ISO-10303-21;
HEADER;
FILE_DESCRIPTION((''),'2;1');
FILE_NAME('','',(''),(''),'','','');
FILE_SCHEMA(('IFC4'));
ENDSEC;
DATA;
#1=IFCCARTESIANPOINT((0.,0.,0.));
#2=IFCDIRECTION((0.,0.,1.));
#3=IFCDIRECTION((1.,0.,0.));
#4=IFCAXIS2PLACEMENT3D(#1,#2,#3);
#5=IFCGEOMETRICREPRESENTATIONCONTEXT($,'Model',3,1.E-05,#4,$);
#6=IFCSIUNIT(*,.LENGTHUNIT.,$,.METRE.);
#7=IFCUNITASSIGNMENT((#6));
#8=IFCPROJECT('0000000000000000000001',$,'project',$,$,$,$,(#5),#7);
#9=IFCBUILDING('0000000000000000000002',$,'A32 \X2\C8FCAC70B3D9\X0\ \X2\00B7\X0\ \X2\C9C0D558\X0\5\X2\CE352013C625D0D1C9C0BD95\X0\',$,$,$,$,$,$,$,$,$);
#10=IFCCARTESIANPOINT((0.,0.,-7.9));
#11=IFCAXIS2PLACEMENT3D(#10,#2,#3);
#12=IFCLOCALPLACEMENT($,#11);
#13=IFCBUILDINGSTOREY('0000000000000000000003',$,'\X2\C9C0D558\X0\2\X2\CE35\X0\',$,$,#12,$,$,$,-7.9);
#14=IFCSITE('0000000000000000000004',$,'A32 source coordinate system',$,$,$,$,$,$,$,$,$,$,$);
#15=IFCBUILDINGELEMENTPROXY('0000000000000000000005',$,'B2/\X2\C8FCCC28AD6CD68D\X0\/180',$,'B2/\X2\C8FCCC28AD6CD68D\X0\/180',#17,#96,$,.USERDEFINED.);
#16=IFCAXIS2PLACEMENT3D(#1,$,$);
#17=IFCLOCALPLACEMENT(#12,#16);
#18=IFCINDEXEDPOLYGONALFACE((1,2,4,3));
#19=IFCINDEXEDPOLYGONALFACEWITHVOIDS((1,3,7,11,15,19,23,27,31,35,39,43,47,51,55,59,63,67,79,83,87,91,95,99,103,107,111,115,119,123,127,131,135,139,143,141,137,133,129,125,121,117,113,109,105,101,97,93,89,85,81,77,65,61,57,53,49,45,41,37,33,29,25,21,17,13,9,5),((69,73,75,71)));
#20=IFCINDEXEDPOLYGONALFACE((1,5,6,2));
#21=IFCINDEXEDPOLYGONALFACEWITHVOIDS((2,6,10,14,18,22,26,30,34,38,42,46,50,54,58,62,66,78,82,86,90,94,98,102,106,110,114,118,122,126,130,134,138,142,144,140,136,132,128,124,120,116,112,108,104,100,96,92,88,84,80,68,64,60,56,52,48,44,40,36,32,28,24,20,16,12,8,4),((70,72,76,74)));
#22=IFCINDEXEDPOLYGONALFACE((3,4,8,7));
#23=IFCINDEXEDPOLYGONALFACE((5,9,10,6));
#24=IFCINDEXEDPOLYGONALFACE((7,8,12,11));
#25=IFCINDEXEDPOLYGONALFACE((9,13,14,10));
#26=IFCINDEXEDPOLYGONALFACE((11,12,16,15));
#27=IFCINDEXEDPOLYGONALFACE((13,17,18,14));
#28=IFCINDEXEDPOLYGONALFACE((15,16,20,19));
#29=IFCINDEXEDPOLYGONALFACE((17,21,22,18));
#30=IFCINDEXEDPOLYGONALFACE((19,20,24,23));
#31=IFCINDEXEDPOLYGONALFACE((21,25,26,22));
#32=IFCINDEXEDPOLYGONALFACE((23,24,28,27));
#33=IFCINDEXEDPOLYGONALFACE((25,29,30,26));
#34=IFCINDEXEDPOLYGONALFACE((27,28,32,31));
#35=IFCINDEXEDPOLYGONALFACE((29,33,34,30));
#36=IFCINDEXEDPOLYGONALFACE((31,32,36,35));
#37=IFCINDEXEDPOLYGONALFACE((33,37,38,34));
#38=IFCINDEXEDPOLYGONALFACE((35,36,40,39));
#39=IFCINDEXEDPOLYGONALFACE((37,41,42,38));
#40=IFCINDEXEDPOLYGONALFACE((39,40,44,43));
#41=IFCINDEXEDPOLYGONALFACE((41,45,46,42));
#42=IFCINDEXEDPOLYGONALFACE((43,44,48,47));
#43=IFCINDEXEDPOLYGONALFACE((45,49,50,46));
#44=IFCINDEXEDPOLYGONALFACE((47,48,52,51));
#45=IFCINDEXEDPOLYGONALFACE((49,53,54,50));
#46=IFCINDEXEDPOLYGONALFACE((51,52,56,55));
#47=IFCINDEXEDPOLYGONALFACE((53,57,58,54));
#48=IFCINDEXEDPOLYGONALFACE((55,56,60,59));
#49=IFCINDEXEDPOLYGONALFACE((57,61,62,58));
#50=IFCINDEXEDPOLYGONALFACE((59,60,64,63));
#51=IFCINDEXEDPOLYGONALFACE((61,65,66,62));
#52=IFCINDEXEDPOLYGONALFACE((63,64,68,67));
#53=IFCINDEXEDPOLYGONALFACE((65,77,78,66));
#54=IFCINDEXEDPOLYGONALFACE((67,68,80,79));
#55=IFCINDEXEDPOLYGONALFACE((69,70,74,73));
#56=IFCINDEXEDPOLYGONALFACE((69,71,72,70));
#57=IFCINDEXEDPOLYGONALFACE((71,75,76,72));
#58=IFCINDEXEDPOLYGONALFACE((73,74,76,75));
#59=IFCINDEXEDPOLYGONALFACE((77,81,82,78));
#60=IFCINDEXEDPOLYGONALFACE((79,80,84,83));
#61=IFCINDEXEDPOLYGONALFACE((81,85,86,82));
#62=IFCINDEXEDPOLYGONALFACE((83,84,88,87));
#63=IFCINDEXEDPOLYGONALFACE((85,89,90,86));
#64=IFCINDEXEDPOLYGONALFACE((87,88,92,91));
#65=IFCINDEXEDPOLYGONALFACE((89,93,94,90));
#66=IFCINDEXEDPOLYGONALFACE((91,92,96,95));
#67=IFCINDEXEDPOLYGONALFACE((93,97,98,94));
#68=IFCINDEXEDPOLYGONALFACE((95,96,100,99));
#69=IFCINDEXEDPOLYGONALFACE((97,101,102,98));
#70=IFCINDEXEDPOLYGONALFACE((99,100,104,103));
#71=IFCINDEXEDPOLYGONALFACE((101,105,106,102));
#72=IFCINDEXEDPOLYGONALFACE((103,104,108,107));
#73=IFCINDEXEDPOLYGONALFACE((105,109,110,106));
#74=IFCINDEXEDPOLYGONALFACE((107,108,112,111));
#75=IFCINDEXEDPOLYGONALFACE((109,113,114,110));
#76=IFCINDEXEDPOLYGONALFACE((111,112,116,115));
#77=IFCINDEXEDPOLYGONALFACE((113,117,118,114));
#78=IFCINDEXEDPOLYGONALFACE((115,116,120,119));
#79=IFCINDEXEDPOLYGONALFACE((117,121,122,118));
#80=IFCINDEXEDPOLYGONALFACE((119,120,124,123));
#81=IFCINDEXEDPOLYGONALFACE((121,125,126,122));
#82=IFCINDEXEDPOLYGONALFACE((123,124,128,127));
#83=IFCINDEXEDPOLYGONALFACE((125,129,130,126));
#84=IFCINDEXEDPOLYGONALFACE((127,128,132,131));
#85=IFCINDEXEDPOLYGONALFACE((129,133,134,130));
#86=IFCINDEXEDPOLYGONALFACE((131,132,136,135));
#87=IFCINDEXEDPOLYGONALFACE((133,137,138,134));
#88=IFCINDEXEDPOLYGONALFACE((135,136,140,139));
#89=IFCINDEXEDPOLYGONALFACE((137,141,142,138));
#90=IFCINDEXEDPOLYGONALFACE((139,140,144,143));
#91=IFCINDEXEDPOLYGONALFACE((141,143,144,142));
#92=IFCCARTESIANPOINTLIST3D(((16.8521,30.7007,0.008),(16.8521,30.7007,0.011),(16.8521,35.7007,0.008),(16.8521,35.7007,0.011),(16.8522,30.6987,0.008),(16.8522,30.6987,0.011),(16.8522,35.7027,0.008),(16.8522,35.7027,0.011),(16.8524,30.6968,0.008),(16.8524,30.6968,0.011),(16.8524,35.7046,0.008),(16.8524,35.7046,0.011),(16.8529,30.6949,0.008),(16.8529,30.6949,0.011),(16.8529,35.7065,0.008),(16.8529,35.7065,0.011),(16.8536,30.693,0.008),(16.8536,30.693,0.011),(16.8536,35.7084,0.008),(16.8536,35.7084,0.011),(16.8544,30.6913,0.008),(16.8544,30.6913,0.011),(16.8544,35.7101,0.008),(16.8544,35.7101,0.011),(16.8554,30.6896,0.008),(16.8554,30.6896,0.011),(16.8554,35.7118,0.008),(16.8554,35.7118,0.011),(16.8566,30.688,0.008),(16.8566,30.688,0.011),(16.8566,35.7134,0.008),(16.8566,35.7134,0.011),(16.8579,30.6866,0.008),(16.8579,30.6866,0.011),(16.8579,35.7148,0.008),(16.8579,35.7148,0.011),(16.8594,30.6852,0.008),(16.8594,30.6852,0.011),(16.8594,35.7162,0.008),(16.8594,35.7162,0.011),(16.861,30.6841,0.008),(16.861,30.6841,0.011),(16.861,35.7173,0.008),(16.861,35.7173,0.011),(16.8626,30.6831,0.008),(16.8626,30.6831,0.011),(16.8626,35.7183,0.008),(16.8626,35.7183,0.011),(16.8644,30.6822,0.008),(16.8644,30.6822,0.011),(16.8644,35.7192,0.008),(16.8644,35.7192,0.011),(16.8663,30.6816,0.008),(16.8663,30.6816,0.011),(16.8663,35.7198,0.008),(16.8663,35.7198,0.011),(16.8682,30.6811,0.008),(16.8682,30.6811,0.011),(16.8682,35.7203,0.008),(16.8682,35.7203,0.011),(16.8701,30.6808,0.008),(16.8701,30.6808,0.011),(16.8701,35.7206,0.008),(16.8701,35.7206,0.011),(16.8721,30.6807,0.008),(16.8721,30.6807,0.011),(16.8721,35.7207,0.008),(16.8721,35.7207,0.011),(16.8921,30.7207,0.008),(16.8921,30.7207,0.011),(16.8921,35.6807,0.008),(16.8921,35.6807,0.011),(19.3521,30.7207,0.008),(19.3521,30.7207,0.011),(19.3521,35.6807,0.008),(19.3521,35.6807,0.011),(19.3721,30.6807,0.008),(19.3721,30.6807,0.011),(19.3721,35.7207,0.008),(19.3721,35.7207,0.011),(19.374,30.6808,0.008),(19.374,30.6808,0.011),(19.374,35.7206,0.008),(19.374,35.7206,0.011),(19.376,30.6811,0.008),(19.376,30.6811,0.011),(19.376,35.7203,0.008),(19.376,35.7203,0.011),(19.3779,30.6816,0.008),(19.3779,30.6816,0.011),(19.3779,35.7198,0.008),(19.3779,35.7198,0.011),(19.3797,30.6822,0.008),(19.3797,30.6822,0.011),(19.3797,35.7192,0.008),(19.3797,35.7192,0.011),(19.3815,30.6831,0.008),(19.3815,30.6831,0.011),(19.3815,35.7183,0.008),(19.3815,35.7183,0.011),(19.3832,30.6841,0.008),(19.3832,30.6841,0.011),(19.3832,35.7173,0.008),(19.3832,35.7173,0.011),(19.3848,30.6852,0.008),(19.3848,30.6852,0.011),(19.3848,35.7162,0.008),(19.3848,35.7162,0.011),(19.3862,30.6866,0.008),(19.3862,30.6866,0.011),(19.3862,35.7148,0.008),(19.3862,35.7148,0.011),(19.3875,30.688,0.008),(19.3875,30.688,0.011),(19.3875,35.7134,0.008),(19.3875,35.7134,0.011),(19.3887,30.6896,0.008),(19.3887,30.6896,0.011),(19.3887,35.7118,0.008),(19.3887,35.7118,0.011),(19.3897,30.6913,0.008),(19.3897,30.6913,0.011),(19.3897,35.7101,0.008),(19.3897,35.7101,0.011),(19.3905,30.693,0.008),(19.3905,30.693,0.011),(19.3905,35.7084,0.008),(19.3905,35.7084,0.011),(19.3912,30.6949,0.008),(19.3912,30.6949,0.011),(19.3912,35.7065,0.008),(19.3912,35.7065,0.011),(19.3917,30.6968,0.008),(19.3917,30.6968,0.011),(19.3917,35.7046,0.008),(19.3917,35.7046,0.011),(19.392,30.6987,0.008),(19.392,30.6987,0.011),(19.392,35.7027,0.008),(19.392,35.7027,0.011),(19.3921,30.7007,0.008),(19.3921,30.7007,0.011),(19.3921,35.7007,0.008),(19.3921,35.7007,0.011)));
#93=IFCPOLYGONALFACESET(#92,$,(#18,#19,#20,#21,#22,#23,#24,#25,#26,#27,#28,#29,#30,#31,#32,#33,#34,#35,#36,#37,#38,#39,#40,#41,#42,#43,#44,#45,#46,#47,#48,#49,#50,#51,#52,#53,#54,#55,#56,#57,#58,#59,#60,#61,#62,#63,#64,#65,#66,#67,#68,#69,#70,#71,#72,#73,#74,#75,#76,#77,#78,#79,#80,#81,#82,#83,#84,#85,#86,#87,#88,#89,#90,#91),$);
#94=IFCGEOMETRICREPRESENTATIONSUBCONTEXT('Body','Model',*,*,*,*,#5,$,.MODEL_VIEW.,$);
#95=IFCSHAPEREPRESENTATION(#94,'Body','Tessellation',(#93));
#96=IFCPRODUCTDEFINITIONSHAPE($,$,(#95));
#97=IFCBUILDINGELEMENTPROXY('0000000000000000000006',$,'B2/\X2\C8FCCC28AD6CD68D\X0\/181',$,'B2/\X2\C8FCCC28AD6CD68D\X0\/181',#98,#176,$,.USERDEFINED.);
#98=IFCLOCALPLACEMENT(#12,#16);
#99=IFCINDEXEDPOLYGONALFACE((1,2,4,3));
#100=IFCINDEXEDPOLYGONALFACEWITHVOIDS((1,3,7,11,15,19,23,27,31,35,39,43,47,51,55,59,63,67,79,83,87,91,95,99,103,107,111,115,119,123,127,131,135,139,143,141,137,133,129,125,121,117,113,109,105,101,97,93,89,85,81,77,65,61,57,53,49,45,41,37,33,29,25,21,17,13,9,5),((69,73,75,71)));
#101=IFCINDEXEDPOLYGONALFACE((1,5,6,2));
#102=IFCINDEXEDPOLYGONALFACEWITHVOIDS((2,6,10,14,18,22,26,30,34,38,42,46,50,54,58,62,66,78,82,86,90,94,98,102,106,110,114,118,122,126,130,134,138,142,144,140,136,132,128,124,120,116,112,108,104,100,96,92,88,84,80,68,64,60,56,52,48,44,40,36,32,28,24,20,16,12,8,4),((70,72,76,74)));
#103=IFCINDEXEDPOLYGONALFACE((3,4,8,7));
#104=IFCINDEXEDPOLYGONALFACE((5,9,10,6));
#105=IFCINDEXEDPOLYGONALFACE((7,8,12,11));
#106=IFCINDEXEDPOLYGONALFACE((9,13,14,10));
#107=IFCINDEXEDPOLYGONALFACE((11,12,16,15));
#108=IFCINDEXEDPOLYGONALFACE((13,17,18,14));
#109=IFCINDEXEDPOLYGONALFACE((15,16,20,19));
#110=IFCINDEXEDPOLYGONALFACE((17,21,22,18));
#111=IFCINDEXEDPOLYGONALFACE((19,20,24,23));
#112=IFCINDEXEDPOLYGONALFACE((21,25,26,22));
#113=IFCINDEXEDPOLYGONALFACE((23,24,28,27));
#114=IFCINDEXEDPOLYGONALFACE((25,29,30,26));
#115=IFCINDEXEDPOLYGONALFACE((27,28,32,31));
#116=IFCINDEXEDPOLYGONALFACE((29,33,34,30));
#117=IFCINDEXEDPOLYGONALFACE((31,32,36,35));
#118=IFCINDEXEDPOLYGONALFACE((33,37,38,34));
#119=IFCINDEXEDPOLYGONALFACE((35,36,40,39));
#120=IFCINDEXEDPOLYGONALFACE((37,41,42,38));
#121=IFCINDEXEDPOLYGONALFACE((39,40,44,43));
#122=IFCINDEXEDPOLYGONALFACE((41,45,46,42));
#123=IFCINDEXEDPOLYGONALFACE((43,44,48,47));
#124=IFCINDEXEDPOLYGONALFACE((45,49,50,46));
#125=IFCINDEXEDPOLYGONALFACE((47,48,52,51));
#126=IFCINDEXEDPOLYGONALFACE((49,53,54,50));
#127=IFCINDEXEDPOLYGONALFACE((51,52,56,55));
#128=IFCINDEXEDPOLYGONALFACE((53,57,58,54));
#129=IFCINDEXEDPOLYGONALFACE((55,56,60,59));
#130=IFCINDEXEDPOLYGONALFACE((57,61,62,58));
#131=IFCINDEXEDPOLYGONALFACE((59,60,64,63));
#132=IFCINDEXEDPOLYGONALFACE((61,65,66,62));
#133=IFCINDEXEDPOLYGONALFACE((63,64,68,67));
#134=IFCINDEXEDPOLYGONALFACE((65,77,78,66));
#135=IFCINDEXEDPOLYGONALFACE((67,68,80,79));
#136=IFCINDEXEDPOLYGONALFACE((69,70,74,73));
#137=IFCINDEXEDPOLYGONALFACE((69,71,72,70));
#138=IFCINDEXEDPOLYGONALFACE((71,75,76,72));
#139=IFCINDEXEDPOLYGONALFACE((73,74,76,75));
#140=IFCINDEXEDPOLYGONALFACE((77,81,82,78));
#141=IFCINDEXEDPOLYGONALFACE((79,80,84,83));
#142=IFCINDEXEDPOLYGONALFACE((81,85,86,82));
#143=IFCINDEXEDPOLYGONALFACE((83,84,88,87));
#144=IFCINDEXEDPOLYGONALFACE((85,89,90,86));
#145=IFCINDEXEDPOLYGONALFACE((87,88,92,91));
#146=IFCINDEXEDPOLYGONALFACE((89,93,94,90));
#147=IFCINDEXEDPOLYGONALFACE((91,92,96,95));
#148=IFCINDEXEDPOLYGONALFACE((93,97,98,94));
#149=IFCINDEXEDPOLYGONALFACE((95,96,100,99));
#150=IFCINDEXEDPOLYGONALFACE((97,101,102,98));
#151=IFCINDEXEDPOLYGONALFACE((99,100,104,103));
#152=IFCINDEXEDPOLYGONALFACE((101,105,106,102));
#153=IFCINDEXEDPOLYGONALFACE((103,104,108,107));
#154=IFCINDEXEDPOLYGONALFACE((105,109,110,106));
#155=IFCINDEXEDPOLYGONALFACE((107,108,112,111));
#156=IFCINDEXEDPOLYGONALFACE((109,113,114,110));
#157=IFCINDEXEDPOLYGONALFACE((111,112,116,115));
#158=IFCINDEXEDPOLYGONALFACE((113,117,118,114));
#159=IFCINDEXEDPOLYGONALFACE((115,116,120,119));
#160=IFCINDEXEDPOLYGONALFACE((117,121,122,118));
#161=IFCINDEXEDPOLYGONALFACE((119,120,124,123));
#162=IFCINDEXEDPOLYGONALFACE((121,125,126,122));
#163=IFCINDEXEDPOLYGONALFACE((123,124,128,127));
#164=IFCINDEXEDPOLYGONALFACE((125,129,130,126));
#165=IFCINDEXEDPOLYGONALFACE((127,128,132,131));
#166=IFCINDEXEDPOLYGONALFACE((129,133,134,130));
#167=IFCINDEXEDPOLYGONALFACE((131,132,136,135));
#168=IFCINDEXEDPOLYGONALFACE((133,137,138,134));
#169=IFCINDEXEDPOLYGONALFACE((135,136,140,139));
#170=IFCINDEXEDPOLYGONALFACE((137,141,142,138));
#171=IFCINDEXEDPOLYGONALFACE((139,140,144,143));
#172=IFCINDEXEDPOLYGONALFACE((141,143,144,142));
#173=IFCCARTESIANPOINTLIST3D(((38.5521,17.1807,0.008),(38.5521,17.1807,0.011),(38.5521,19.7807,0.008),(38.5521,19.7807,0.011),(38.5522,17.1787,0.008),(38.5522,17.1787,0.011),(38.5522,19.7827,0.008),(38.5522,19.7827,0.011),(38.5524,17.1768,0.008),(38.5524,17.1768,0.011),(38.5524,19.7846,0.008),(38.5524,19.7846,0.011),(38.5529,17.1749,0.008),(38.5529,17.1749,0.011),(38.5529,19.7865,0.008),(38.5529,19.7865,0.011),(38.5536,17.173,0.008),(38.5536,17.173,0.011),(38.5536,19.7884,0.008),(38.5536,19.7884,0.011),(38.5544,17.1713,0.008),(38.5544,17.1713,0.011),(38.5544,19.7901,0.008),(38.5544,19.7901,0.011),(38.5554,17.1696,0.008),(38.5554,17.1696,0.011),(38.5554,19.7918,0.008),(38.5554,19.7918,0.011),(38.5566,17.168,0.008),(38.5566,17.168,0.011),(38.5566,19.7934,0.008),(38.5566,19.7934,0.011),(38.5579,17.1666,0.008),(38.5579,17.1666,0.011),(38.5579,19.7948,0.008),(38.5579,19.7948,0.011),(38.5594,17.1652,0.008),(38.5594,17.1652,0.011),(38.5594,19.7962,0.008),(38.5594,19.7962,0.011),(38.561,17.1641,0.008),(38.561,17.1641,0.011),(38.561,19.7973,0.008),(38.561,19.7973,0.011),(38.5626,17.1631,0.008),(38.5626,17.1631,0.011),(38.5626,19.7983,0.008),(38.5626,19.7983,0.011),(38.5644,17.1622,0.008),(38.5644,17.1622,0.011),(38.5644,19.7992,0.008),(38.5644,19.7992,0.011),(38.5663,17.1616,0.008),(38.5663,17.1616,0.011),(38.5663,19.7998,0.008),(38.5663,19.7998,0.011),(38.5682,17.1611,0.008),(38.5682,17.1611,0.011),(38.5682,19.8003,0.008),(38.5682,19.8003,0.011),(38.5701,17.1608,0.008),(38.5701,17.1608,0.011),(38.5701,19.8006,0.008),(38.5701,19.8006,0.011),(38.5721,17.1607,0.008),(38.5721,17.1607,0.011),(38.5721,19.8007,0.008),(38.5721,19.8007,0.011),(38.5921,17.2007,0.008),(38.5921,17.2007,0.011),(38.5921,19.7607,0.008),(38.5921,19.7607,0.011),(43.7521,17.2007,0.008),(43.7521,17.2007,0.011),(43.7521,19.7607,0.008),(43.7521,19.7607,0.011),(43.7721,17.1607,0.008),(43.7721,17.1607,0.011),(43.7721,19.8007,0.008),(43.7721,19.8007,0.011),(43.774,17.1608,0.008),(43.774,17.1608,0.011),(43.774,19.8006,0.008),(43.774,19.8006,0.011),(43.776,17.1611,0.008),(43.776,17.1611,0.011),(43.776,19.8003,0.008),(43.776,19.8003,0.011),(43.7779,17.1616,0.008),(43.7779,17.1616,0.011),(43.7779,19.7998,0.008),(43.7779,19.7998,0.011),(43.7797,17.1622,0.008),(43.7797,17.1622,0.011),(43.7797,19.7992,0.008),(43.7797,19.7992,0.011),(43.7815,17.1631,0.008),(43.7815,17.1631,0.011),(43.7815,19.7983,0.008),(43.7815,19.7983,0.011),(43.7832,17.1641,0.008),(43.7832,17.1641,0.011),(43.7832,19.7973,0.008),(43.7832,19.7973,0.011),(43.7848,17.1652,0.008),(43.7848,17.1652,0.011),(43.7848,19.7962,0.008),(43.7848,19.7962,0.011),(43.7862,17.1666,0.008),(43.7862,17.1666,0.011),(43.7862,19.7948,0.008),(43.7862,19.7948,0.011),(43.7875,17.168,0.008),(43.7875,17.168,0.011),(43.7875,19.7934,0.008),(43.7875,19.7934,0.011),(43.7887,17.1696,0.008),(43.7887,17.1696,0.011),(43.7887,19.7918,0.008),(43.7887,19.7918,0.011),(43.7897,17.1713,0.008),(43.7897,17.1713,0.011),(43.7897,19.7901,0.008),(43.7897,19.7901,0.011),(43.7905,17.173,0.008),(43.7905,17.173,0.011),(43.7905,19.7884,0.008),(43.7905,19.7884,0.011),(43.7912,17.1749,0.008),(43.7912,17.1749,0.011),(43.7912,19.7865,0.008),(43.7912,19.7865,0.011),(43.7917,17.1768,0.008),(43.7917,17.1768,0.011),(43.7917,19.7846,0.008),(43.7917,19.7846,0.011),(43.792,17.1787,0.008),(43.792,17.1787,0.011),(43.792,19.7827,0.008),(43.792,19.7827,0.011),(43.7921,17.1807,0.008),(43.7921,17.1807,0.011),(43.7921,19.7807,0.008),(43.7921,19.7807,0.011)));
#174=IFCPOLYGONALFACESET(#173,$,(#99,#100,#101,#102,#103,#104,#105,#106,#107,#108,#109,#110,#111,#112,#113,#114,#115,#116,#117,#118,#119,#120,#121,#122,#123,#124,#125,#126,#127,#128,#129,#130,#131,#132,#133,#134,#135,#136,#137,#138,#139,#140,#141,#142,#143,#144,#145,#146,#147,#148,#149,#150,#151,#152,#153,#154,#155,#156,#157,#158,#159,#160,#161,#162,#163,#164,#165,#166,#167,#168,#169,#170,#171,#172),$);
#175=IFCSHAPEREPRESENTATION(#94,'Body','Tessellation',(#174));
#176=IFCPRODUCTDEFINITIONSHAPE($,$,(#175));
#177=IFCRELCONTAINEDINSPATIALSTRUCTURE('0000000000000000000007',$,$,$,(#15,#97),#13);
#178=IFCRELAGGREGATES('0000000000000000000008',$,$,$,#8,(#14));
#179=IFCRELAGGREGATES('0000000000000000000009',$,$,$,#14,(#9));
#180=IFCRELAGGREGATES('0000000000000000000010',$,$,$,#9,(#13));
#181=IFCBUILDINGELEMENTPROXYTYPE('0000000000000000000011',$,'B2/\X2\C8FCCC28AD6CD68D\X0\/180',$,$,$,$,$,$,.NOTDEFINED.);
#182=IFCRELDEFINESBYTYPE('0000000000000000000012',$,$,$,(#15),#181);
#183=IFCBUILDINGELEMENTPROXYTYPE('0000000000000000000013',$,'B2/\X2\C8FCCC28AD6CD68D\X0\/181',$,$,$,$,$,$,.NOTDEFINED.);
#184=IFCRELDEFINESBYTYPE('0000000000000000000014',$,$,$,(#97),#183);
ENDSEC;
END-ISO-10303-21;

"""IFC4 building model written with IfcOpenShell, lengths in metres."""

from ifc_helpers import new_model, si_unit, frame, origin, origin_with_axes, place, context, subcontext, project, spatial, polyline, outline, extrude, source, transform, mapped, type_object, type_shapes, element, save


model = new_model("IFC4")

# Units and contexts
model_context = context("Model", 3, precision=1e-05, world=origin_with_axes())
body_context = subcontext(model_context, "Body", "Model", "MODEL_VIEW")
ifc_project = project(units=[si_unit("LENGTHUNIT", "METRE")], contexts=[model_context])

# Site, building, storey
site = spatial("IfcSite", under=ifc_project, Name="A32 source coordinate system")
building = spatial("IfcBuilding", under=site, Name="A32 주거동 · 지하5층–옥탑지붕")
storey_placement = place(None, frame((0.0, 0.0, -7.9), z_axis=(0.0, 0.0, 1.0), x_axis=(1.0, 0.0, 0.0)))
storey = spatial("IfcBuildingStorey", under=building, at=storey_placement, Name="지하2층", Elevation=-7.9)

# Building element proxies
building_element_proxy_type_1 = type_object("IfcBuildingElementProxyType", Name="B2/주차구획/180", PredefinedType="NOTDEFINED")
shared_shape_1 = source(origin(), body_context, "Body", "SweptSolid", [
    extrude(outline(polyline([(16.8521, 35.7007), (16.8522, 35.7027), (16.8524, 35.7046), (16.8529, 35.7065), (16.8536, 35.7084), (16.8544, 35.7101), (16.8554, 35.7118), (16.8566, 35.7134), (16.8579, 35.7148), (16.8594, 35.7162), (16.861, 35.7173), (16.8626, 35.7183), (16.8644, 35.7192), (16.8663, 35.7198), (16.8682, 35.7203), (16.8701, 35.7206), (16.8721, 35.7207), (19.3721, 35.7207), (19.374, 35.7206), (19.376, 35.7203), (19.3779, 35.7198), (19.3797, 35.7192), (19.3815, 35.7183), (19.3832, 35.7173), (19.3848, 35.7162), (19.3862, 35.7148), (19.3875, 35.7134), (19.3887, 35.7118), (19.3897, 35.7101), (19.3905, 35.7084), (19.3912, 35.7065), (19.3917, 35.7046), (19.392, 35.7027), (19.3921, 35.7007), (19.3921, 30.7007), (19.392, 30.6987), (19.3917, 30.6968), (19.3912, 30.6949), (19.3905, 30.693), (19.3897, 30.6913), (19.3887, 30.6896), (19.3875, 30.688), (19.3862, 30.6866), (19.3848, 30.6852), (19.3832, 30.6841), (19.3815, 30.6831), (19.3797, 30.6822), (19.3779, 30.6816), (19.376, 30.6811), (19.374, 30.6808), (19.3721, 30.6807), (16.8721, 30.6807), (16.8701, 30.6808), (16.8682, 30.6811), (16.8663, 30.6816), (16.8644, 30.6822), (16.8626, 30.6831), (16.861, 30.6841), (16.8594, 30.6852), (16.8579, 30.6866), (16.8566, 30.688), (16.8554, 30.6896), (16.8544, 30.6913), (16.8536, 30.693), (16.8529, 30.6949), (16.8524, 30.6968), (16.8522, 30.6987), (16.8521, 30.7007), (16.8521, 35.7007)]), holes=[polyline([(16.8921, 35.6807), (16.8921, 30.7207), (19.3521, 30.7207), (19.3521, 35.6807), (16.8921, 35.6807)])]), frame((0.0, 0.0, 0.008)), (0.0, 0.0, 1.0), 0.003),
])
type_shapes(building_element_proxy_type_1, [shared_shape_1])
proxy_1_placement = place(storey_placement, origin_with_axes())
element("IfcBuildingElementProxy", 1, at=proxy_1_placement, inside=storey, type_object=building_element_proxy_type_1, Name="B2/주차구획/180", ObjectType="B2/주차구획/180", PredefinedType="USERDEFINED", context=body_context, shape_type="MappedRepresentation", body=[
    mapped(shared_shape_1, transform((0.0, 0.0, 0.0), scale=1.0)),
])
building_element_proxy_type_2 = type_object("IfcBuildingElementProxyType", Name="B2/주차구획/181", PredefinedType="NOTDEFINED")
shared_shape_2 = source(origin(), body_context, "Body", "SweptSolid", [
    extrude(outline(polyline([(43.7721, 19.8007), (43.774, 19.8006), (43.776, 19.8003), (43.7779, 19.7998), (43.7797, 19.7992), (43.7815, 19.7983), (43.7832, 19.7973), (43.7848, 19.7962), (43.7862, 19.7948), (43.7875, 19.7934), (43.7887, 19.7918), (43.7897, 19.7901), (43.7905, 19.7884), (43.7912, 19.7865), (43.7917, 19.7846), (43.792, 19.7827), (43.7921, 19.7807), (43.7921, 17.1807), (43.792, 17.1787), (43.7917, 17.1768), (43.7912, 17.1749), (43.7905, 17.173), (43.7897, 17.1713), (43.7887, 17.1696), (43.7875, 17.168), (43.7862, 17.1666), (43.7848, 17.1652), (43.7832, 17.1641), (43.7815, 17.1631), (43.7797, 17.1622), (43.7779, 17.1616), (43.776, 17.1611), (43.774, 17.1608), (43.7721, 17.1607), (38.5721, 17.1607), (38.5701, 17.1608), (38.5682, 17.1611), (38.5663, 17.1616), (38.5644, 17.1622), (38.5626, 17.1631), (38.561, 17.1641), (38.5594, 17.1652), (38.5579, 17.1666), (38.5566, 17.168), (38.5554, 17.1696), (38.5544, 17.1713), (38.5536, 17.173), (38.5529, 17.1749), (38.5524, 17.1768), (38.5522, 17.1787), (38.5521, 17.1807), (38.5521, 19.7807), (38.5522, 19.7827), (38.5524, 19.7846), (38.5529, 19.7865), (38.5536, 19.7884), (38.5544, 19.7901), (38.5554, 19.7918), (38.5566, 19.7934), (38.5579, 19.7948), (38.5594, 19.7962), (38.561, 19.7973), (38.5626, 19.7983), (38.5644, 19.7992), (38.5663, 19.7998), (38.5682, 19.8003), (38.5701, 19.8006), (38.5721, 19.8007), (43.7721, 19.8007)]), holes=[polyline([(43.7521, 19.7607), (38.5921, 19.7607), (38.5921, 17.2007), (43.7521, 17.2007), (43.7521, 19.7607)])]), frame((0.0, 0.0, 0.008)), (0.0, 0.0, 1.0), 0.003),
])
type_shapes(building_element_proxy_type_2, [shared_shape_2])
proxy_2_placement = place(storey_placement, origin_with_axes())
element("IfcBuildingElementProxy", 2, at=proxy_2_placement, inside=storey, type_object=building_element_proxy_type_2, Name="B2/주차구획/181", ObjectType="B2/주차구획/181", PredefinedType="USERDEFINED", context=body_context, shape_type="MappedRepresentation", body=[
    mapped(shared_shape_2, transform((0.0, 0.0, 0.0), scale=1.0)),
])

save(model, "model.ifc")
